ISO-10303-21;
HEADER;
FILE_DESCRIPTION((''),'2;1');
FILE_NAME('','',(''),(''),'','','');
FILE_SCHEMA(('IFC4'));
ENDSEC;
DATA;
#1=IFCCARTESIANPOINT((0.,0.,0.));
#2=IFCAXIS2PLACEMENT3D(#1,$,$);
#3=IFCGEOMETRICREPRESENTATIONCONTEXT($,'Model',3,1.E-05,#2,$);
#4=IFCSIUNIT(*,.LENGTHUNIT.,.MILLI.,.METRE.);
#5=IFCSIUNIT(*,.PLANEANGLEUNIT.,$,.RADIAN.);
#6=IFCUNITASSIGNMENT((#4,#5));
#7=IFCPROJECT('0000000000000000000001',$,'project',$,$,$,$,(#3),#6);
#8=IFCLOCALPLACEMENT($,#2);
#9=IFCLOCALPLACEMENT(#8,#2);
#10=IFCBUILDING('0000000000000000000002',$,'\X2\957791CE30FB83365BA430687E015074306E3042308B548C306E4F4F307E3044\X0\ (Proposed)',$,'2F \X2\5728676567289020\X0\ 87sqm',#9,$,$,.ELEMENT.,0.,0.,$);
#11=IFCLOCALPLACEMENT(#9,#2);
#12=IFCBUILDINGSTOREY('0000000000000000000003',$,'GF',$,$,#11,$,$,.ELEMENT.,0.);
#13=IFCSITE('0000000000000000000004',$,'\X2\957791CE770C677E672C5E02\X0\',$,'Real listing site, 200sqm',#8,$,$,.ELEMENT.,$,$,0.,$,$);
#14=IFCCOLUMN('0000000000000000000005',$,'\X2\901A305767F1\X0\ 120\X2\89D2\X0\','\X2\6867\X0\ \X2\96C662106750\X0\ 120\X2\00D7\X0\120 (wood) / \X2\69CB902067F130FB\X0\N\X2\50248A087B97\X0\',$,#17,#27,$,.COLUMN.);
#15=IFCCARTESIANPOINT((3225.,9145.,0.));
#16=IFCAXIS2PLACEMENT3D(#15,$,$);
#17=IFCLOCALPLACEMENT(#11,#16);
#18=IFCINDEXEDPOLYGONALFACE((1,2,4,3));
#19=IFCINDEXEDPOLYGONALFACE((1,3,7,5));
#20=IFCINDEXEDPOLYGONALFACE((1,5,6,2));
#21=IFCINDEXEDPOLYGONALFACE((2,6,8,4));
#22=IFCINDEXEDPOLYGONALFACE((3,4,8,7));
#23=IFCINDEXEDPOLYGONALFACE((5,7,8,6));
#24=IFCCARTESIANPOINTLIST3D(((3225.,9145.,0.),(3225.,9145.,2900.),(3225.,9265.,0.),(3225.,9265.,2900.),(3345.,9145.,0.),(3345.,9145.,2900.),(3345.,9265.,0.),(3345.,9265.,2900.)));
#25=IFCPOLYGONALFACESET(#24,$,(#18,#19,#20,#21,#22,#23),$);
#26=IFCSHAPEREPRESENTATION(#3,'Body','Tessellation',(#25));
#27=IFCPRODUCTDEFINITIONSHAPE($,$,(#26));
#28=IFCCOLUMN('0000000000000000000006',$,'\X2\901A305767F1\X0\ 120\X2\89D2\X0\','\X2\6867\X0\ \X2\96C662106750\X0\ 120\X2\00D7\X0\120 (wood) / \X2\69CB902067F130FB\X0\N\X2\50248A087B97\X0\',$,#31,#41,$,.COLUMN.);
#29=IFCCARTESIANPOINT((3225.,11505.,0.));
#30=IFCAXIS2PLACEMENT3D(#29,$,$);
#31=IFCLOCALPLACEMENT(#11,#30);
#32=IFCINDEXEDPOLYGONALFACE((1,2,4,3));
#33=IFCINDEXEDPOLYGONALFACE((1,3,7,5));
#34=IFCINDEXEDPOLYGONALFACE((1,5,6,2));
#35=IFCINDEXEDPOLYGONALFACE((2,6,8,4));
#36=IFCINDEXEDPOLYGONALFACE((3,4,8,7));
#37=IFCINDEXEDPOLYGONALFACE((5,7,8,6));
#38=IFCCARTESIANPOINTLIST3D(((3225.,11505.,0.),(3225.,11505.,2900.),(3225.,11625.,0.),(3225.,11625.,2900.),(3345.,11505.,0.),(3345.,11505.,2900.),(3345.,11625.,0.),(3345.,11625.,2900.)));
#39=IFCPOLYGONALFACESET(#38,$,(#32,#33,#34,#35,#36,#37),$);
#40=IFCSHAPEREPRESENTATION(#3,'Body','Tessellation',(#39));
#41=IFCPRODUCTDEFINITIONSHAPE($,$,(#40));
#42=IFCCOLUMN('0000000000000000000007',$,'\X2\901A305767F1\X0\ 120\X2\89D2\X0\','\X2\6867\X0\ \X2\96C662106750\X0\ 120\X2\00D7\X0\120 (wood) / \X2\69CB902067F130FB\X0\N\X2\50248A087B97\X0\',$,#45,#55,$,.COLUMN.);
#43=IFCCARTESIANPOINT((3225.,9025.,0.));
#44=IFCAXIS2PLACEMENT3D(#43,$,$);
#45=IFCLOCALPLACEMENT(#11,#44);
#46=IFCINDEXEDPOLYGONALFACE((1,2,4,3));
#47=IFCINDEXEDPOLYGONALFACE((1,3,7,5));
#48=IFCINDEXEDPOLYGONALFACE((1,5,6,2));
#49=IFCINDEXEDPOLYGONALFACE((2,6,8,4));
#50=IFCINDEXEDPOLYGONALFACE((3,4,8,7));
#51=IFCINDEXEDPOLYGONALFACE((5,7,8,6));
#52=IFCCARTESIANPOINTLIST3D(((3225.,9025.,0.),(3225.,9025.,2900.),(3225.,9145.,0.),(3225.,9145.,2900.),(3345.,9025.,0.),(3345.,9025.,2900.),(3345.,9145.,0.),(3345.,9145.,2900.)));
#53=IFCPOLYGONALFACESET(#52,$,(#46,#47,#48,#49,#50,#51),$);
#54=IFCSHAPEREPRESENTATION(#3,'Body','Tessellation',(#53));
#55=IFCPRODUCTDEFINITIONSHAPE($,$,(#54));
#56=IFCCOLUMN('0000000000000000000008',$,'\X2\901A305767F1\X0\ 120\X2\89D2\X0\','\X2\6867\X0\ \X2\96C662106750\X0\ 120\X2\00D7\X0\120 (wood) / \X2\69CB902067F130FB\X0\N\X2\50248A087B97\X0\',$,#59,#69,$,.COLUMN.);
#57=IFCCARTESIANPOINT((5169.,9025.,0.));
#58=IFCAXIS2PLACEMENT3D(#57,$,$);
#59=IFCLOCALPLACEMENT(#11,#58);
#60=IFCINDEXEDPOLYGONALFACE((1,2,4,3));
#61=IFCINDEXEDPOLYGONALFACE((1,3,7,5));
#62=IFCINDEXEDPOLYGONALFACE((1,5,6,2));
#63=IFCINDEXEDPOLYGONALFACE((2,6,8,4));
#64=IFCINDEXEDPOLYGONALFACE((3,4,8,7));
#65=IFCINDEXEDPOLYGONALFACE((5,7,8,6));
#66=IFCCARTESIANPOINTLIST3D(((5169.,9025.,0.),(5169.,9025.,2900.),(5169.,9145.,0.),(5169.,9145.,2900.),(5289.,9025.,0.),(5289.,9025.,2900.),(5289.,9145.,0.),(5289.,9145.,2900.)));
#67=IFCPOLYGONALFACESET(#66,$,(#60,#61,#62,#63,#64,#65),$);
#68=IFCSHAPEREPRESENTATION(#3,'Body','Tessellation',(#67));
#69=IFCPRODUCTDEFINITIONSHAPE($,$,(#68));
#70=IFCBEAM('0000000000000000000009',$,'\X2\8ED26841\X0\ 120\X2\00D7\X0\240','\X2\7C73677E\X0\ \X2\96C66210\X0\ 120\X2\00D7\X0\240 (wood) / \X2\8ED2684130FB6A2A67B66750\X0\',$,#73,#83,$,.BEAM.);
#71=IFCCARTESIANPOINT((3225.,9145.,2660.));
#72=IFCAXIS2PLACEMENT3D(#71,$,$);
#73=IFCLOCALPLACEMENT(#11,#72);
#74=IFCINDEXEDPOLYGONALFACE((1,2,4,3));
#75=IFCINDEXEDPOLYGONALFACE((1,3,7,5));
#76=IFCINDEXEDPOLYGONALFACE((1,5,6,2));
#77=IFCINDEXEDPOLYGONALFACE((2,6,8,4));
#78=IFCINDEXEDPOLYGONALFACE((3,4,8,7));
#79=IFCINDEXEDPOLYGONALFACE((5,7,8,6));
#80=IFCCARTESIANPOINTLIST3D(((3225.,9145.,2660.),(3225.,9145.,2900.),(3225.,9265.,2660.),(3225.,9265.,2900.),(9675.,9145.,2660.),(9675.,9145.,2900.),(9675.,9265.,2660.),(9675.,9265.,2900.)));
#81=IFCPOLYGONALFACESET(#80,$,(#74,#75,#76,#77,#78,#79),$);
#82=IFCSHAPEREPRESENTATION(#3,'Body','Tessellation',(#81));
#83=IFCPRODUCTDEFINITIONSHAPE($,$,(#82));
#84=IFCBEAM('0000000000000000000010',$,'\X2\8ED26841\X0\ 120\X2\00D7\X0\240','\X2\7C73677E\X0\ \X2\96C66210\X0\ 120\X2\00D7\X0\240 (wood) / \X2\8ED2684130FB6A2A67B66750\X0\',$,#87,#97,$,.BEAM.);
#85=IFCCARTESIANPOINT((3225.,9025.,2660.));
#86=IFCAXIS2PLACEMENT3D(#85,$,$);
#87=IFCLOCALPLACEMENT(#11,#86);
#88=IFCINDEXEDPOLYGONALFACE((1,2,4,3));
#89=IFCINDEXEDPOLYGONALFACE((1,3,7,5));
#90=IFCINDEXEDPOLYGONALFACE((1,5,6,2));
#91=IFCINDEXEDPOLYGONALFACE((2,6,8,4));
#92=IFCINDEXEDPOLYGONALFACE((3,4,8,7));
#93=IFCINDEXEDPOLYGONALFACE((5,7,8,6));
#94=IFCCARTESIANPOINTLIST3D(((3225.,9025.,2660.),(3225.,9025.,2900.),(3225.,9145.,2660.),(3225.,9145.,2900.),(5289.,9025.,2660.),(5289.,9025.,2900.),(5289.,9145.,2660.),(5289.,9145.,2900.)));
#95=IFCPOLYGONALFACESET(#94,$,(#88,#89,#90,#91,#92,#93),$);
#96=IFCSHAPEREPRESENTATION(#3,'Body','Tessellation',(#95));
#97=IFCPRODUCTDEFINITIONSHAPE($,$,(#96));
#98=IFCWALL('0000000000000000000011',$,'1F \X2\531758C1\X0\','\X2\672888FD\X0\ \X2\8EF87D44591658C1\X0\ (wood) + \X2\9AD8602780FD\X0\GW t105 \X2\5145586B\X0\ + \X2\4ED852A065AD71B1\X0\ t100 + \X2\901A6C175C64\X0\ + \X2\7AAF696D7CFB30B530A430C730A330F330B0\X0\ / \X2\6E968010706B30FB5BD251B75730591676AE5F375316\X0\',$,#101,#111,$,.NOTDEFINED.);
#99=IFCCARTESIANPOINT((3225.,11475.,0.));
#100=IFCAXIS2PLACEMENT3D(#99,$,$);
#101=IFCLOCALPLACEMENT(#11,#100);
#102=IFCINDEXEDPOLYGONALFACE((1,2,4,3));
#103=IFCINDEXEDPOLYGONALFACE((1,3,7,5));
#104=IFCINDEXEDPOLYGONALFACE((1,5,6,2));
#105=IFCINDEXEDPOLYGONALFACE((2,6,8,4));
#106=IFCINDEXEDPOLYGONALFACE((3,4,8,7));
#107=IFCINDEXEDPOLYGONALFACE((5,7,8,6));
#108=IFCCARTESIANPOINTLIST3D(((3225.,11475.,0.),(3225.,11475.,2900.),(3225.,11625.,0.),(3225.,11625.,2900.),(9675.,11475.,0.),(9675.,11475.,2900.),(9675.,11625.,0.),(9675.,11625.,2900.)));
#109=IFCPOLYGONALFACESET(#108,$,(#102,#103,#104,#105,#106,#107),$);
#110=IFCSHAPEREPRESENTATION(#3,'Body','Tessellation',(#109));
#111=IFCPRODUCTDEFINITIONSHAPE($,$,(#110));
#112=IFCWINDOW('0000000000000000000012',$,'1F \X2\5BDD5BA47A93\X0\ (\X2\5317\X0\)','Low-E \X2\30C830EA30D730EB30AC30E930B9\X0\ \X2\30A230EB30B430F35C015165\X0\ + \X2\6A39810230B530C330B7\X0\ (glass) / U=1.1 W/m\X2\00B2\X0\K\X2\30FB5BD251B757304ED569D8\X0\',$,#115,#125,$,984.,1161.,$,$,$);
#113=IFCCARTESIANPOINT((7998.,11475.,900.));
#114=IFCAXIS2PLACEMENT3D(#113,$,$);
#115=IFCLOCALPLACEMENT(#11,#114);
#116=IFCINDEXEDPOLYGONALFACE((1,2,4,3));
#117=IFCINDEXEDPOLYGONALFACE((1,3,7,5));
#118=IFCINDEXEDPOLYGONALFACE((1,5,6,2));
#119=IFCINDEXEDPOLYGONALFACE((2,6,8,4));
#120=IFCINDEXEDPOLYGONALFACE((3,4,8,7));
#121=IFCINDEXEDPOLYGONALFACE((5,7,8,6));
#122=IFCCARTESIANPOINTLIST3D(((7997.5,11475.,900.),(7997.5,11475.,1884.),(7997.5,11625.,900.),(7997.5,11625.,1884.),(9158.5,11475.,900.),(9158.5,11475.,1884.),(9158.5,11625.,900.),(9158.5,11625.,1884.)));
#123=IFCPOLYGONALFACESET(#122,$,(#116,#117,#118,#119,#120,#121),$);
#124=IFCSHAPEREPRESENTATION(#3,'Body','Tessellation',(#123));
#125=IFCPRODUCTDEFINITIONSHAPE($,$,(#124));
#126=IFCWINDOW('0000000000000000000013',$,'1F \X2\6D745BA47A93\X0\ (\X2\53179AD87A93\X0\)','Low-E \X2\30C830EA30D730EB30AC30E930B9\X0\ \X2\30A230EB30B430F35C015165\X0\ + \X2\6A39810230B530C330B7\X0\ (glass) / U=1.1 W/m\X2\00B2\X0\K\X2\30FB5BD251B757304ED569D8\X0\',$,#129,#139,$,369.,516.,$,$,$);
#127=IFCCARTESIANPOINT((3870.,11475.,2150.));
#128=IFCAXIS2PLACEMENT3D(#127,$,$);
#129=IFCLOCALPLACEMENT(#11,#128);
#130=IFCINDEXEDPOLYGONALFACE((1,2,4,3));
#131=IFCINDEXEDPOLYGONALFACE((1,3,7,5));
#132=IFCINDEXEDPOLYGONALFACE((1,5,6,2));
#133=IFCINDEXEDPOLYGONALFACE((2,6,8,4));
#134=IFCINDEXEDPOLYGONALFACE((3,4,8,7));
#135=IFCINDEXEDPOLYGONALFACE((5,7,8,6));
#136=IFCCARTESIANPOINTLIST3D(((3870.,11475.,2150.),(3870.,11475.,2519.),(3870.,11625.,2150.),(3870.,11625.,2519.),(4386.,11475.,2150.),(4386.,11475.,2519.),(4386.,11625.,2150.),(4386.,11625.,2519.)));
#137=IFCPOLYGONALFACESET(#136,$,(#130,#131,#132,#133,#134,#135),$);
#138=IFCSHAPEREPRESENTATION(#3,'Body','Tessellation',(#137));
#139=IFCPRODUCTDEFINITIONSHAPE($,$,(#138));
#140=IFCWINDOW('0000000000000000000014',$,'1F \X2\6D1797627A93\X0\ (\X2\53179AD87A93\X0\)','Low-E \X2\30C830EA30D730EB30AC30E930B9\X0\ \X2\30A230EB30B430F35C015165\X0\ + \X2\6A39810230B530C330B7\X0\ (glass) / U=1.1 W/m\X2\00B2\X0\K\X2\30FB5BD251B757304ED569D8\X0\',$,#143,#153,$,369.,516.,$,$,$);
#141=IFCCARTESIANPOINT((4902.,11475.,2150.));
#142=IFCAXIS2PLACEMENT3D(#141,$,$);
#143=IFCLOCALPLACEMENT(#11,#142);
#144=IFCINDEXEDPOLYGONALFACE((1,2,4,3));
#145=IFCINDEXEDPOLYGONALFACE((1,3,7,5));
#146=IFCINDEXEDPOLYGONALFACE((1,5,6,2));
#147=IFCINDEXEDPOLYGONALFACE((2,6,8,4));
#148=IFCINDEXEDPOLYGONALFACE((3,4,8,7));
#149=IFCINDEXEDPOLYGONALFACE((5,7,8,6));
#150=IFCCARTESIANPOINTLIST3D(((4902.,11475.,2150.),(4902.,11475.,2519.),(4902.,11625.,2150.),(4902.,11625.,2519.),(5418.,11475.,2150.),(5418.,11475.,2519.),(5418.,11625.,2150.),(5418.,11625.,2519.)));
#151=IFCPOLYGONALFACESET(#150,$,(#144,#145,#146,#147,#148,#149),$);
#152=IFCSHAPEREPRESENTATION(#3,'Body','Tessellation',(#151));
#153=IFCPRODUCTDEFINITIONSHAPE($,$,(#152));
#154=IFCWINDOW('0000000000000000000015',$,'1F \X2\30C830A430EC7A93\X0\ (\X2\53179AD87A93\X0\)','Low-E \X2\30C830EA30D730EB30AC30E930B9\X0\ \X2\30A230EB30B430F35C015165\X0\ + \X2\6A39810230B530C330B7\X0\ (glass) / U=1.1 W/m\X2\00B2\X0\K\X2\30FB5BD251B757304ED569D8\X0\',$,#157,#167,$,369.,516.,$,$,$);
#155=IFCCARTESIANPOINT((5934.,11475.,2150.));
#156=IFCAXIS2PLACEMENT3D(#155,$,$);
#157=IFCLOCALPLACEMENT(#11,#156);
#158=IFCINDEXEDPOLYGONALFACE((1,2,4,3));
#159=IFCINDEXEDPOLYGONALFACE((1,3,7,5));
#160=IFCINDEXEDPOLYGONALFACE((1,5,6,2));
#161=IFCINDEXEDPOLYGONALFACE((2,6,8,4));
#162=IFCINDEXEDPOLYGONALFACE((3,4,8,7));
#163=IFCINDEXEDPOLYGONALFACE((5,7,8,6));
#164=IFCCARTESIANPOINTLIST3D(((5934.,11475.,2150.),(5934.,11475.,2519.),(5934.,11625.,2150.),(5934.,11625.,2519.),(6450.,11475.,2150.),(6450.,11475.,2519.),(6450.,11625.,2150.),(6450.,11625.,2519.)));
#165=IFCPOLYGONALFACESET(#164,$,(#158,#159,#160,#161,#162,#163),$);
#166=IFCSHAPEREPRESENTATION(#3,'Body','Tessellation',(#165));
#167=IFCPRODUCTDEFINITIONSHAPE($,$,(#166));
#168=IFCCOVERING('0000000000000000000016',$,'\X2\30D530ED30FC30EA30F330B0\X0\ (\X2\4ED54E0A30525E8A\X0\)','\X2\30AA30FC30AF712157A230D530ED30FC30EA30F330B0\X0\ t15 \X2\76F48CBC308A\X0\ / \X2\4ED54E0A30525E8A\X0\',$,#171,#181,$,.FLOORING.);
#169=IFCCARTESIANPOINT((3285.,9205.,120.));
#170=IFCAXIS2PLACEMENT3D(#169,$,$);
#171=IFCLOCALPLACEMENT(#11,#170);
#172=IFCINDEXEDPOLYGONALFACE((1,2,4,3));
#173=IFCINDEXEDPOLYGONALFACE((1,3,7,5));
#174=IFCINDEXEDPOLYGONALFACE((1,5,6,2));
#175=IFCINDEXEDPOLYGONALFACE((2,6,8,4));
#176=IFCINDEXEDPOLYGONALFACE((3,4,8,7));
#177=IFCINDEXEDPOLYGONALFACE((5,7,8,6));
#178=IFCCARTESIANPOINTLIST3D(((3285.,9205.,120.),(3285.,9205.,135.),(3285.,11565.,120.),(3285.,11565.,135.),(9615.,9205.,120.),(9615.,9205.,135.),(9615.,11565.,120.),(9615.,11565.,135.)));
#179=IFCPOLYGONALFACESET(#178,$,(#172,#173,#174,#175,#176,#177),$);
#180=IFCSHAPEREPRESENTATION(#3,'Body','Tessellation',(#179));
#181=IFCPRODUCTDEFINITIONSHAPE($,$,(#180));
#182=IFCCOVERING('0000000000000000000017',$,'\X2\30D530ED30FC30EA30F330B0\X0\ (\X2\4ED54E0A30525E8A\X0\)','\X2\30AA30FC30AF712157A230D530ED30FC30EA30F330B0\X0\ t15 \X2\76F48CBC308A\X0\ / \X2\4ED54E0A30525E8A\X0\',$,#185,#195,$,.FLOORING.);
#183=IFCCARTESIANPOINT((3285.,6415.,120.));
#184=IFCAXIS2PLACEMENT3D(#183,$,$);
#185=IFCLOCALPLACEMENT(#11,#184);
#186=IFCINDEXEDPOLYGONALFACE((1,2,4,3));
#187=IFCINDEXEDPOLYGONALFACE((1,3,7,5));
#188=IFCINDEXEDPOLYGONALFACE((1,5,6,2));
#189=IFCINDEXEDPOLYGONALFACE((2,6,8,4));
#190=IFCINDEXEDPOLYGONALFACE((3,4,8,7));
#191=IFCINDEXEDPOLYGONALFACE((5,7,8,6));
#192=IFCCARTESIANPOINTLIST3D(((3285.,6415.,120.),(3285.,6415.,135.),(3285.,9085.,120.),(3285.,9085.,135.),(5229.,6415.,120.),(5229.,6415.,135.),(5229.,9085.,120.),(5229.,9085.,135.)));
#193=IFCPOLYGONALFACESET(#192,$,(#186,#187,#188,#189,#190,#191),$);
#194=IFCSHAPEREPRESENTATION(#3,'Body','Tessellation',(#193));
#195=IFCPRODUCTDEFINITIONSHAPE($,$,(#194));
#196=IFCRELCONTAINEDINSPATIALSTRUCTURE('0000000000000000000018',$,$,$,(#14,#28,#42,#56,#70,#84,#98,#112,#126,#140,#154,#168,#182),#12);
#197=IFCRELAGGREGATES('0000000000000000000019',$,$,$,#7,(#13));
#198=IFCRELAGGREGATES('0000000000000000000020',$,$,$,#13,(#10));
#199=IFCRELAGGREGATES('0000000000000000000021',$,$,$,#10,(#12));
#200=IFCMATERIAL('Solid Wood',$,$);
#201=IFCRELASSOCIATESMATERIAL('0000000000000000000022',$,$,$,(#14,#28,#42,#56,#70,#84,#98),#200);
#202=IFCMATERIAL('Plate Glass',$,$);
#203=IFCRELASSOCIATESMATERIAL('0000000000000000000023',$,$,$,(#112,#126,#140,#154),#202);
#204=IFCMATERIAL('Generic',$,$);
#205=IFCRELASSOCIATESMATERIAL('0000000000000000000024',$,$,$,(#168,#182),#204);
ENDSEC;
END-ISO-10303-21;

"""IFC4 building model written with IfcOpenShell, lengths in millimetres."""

from ifc_helpers import new_model, si_unit, frame, frame_2d, origin, place, context, project, spatial, rectangle, extrude, material, element, fill, save


model = new_model("IFC4")

# Units and contexts
model_context = context("Model", 3, precision=1e-05, world=origin())
ifc_project = project(units=[si_unit("LENGTHUNIT", "METRE", prefix="MILLI"), si_unit("PLANEANGLEUNIT", "RADIAN")], contexts=[model_context])

# Site, building, storey
site_placement = place(None, origin())
site = spatial("IfcSite", under=ifc_project, at=site_placement, Name="長野県松本市", ObjectType="Real listing site, 200sqm", CompositionType="ELEMENT", RefElevation=0.0)
building_placement = place(site_placement, origin())
building = spatial("IfcBuilding", under=site, at=building_placement, Name="長野・茶室と縁側のある和の住まい (Proposed)", ObjectType="2F 在来木造 87sqm", CompositionType="ELEMENT", ElevationOfRefHeight=0.0, ElevationOfTerrain=0.0)
storey_placement = place(building_placement, origin())
storey = spatial("IfcBuildingStorey", under=building, at=storey_placement, Name="GF", CompositionType="ELEMENT", Elevation=0.0)

# Columns
ifc_material_1 = material(Name="Solid Wood")
column_1_placement = place(storey_placement, frame((3225.0, 9145.0, 0.0)))
element("IfcColumn", 1, at=column_1_placement, inside=storey, material=ifc_material_1, Name="通し柱 120角", Description="桧 集成材 120×120 (wood) / 構造柱・N値計算", PredefinedType="COLUMN", context=model_context, shape_type="SweptSolid", body=[
    extrude(rectangle(XDim=120.0, YDim=120.0, at=frame_2d((60.0, 60.0))), frame((3225.0, 9145.0, 0.0)), (0.0, 0.0, 1.0), 2900.0),
])
column_2_placement = place(storey_placement, frame((3225.0, 11505.0, 0.0)))
element("IfcColumn", 2, at=column_2_placement, inside=storey, material=ifc_material_1, Name="通し柱 120角", Description="桧 集成材 120×120 (wood) / 構造柱・N値計算", PredefinedType="COLUMN", context=model_context, shape_type="SweptSolid", body=[
    extrude(rectangle(XDim=120.0, YDim=120.0, at=frame_2d((60.0, 60.0))), frame((3225.0, 11505.0, 0.0)), (0.0, 0.0, 1.0), 2900.0),
])
column_3_placement = place(storey_placement, frame((3225.0, 9025.0, 0.0)))
element("IfcColumn", 3, at=column_3_placement, inside=storey, material=ifc_material_1, Name="通し柱 120角", Description="桧 集成材 120×120 (wood) / 構造柱・N値計算", PredefinedType="COLUMN", context=model_context, shape_type="SweptSolid", body=[
    extrude(rectangle(XDim=120.0, YDim=120.0, at=frame_2d((60.0, 60.0))), frame((3225.0, 9025.0, 0.0)), (0.0, 0.0, 1.0), 2900.0),
])
column_4_placement = place(storey_placement, frame((5169.0, 9025.0, 0.0)))
element("IfcColumn", 4, at=column_4_placement, inside=storey, material=ifc_material_1, Name="通し柱 120角", Description="桧 集成材 120×120 (wood) / 構造柱・N値計算", PredefinedType="COLUMN", context=model_context, shape_type="SweptSolid", body=[
    extrude(rectangle(XDim=120.0, YDim=120.0, at=frame_2d((60.0, 60.0))), frame((5169.0, 9025.0, 0.0)), (0.0, 0.0, 1.0), 2900.0),
])

# Beams
beam_1_placement = place(storey_placement, frame((3225.0, 9145.0, 2660.0)))
element("IfcBeam", 5, at=beam_1_placement, inside=storey, material=ifc_material_1, Name="軒桁 120×240", Description="米松 集成 120×240 (wood) / 軒桁・横架材", PredefinedType="BEAM", context=model_context, shape_type="SweptSolid", body=[
    extrude(rectangle(XDim=6450.0, YDim=120.0, at=frame_2d((3225.0, 60.0))), frame((3225.0, 9145.0, 2660.0)), (0.0, 0.0, 1.0), 240.0),
])
beam_2_placement = place(storey_placement, frame((3225.0, 9025.0, 2660.0)))
element("IfcBeam", 6, at=beam_2_placement, inside=storey, material=ifc_material_1, Name="軒桁 120×240", Description="米松 集成 120×240 (wood) / 軒桁・横架材", PredefinedType="BEAM", context=model_context, shape_type="SweptSolid", body=[
    extrude(rectangle(XDim=2064.0, YDim=120.0, at=frame_2d((1032.0, 60.0))), frame((3225.0, 9025.0, 2660.0)), (0.0, 0.0, 1.0), 240.0),
])

# Wall, openings, windows
wall_1_placement = place(storey_placement, frame((3225.0, 11475.0, 0.0)))
wall_1 = element("IfcWall", 7, at=wall_1_placement, inside=storey, material=ifc_material_1, Name="1F 北壁", Description="木製 軸組外壁 (wood) + 高性能GW t105 充填 + 付加断熱 t100 + 通気層 + 窯業系サイディング / 準耐火・寒冷地外皮強化", PredefinedType="NOTDEFINED", context=model_context, shape_type="SweptSolid", body=[
    extrude(rectangle(XDim=6450.0, YDim=150.0, at=frame_2d((3225.0, 75.0))), frame((3225.0, 11475.0, 0.0)), (0.0, 0.0, 1.0), 2900.0),
])
opening_1_placement = place(storey_placement, frame((7998.0, 11475.0, 900.0)))
opening_1 = element("IfcOpeningElement", 8, at=opening_1_placement, cuts=wall_1, PredefinedType="NOTDEFINED", context=model_context, shape_type="SweptSolid", body=[
    extrude(rectangle(XDim=1161.0, YDim=150.0, at=frame_2d((580.0, 75.0))), frame((7998.0, 11475.0, 900.0)), (0.0, 0.0, 1.0), 984.0),
])
opening_2_placement = place(storey_placement, frame((3870.0, 11475.0, 2150.0)))
opening_2 = element("IfcOpeningElement", 9, at=opening_2_placement, cuts=wall_1, PredefinedType="NOTDEFINED", context=model_context, shape_type="SweptSolid", body=[
    extrude(rectangle(XDim=516.0, YDim=150.0, at=frame_2d((258.0, 75.0))), frame((3870.0, 11475.0, 2150.0)), (0.0, 0.0, 1.0), 369.0),
])
opening_3_placement = place(storey_placement, frame((4902.0, 11475.0, 2150.0)))
opening_3 = element("IfcOpeningElement", 10, at=opening_3_placement, cuts=wall_1, PredefinedType="NOTDEFINED", context=model_context, shape_type="SweptSolid", body=[
    extrude(rectangle(XDim=516.0, YDim=150.0, at=frame_2d((258.0, 75.0))), frame((4902.0, 11475.0, 2150.0)), (0.0, 0.0, 1.0), 369.0),
])
opening_4_placement = place(storey_placement, frame((5934.0, 11475.0, 2150.0)))
opening_4 = element("IfcOpeningElement", 11, at=opening_4_placement, cuts=wall_1, PredefinedType="NOTDEFINED", context=model_context, shape_type="SweptSolid", body=[
    extrude(rectangle(XDim=516.0, YDim=150.0, at=frame_2d((258.0, 75.0))), frame((5934.0, 11475.0, 2150.0)), (0.0, 0.0, 1.0), 369.0),
])
ifc_material_2 = material(Name="Plate Glass")
window_1_placement = place(storey_placement, frame((7998.0, 11475.0, 900.0)))
window_1 = element("IfcWindow", 12, at=window_1_placement, inside=storey, material=ifc_material_2, Name="1F 寝室窓 (北)", Description="Low-E トリプルガラス アルゴン封入 + 樹脂サッシ (glass) / U=1.1 W/m²K・寒冷地仕様", OverallHeight=984.0, OverallWidth=1161.0, context=model_context, shape_type="SweptSolid", body=[
    extrude(rectangle(XDim=1161.0, YDim=150.0, at=frame_2d((580.0, 75.0))), frame((7998.0, 11475.0, 900.0)), (0.0, 0.0, 1.0), 984.0),
])
fill(opening_1, window_1)
window_2_placement = place(storey_placement, frame((3870.0, 11475.0, 2150.0)))
window_2 = element("IfcWindow", 13, at=window_2_placement, inside=storey, material=ifc_material_2, Name="1F 浴室窓 (北高窓)", Description="Low-E トリプルガラス アルゴン封入 + 樹脂サッシ (glass) / U=1.1 W/m²K・寒冷地仕様", OverallHeight=369.0, OverallWidth=516.0, context=model_context, shape_type="SweptSolid", body=[
    extrude(rectangle(XDim=516.0, YDim=150.0, at=frame_2d((258.0, 75.0))), frame((3870.0, 11475.0, 2150.0)), (0.0, 0.0, 1.0), 369.0),
])
fill(opening_2, window_2)
window_3_placement = place(storey_placement, frame((4902.0, 11475.0, 2150.0)))
window_3 = element("IfcWindow", 14, at=window_3_placement, inside=storey, material=ifc_material_2, Name="1F 洗面窓 (北高窓)", Description="Low-E トリプルガラス アルゴン封入 + 樹脂サッシ (glass) / U=1.1 W/m²K・寒冷地仕様", OverallHeight=369.0, OverallWidth=516.0, context=model_context, shape_type="SweptSolid", body=[
    extrude(rectangle(XDim=516.0, YDim=150.0, at=frame_2d((258.0, 75.0))), frame((4902.0, 11475.0, 2150.0)), (0.0, 0.0, 1.0), 369.0),
])
fill(opening_3, window_3)
window_4_placement = place(storey_placement, frame((5934.0, 11475.0, 2150.0)))
window_4 = element("IfcWindow", 15, at=window_4_placement, inside=storey, material=ifc_material_2, Name="1F トイレ窓 (北高窓)", Description="Low-E トリプルガラス アルゴン封入 + 樹脂サッシ (glass) / U=1.1 W/m²K・寒冷地仕様", OverallHeight=369.0, OverallWidth=516.0, context=model_context, shape_type="SweptSolid", body=[
    extrude(rectangle(XDim=516.0, YDim=150.0, at=frame_2d((258.0, 75.0))), frame((5934.0, 11475.0, 2150.0)), (0.0, 0.0, 1.0), 369.0),
])
fill(opening_4, window_4)

# Coverings
ifc_material_3 = material(Name="Generic")
covering_1_placement = place(storey_placement, frame((3285.0, 9205.0, 120.0)))
element("IfcCovering", 16, at=covering_1_placement, inside=storey, material=ifc_material_3, Name="フローリング (仕上げ床)", Description="オーク無垢フローリング t15 直貼り / 仕上げ床", PredefinedType="FLOORING", context=model_context, shape_type="SweptSolid", body=[
    extrude(rectangle(XDim=6330.0, YDim=2360.0, at=frame_2d((3165.0, 1180.0))), frame((3285.0, 9205.0, 120.0)), (0.0, 0.0, 1.0), 15.0),
])
covering_2_placement = place(storey_placement, frame((3285.0, 6415.0, 120.0)))
element("IfcCovering", 17, at=covering_2_placement, inside=storey, material=ifc_material_3, Name="フローリング (仕上げ床)", Description="オーク無垢フローリング t15 直貼り / 仕上げ床", PredefinedType="FLOORING", context=model_context, shape_type="SweptSolid", body=[
    extrude(rectangle(XDim=1944.0, YDim=2670.0, at=frame_2d((972.0, 1335.0))), frame((3285.0, 6415.0, 120.0)), (0.0, 0.0, 1.0), 15.0),
])

save(model, "model.ifc")
